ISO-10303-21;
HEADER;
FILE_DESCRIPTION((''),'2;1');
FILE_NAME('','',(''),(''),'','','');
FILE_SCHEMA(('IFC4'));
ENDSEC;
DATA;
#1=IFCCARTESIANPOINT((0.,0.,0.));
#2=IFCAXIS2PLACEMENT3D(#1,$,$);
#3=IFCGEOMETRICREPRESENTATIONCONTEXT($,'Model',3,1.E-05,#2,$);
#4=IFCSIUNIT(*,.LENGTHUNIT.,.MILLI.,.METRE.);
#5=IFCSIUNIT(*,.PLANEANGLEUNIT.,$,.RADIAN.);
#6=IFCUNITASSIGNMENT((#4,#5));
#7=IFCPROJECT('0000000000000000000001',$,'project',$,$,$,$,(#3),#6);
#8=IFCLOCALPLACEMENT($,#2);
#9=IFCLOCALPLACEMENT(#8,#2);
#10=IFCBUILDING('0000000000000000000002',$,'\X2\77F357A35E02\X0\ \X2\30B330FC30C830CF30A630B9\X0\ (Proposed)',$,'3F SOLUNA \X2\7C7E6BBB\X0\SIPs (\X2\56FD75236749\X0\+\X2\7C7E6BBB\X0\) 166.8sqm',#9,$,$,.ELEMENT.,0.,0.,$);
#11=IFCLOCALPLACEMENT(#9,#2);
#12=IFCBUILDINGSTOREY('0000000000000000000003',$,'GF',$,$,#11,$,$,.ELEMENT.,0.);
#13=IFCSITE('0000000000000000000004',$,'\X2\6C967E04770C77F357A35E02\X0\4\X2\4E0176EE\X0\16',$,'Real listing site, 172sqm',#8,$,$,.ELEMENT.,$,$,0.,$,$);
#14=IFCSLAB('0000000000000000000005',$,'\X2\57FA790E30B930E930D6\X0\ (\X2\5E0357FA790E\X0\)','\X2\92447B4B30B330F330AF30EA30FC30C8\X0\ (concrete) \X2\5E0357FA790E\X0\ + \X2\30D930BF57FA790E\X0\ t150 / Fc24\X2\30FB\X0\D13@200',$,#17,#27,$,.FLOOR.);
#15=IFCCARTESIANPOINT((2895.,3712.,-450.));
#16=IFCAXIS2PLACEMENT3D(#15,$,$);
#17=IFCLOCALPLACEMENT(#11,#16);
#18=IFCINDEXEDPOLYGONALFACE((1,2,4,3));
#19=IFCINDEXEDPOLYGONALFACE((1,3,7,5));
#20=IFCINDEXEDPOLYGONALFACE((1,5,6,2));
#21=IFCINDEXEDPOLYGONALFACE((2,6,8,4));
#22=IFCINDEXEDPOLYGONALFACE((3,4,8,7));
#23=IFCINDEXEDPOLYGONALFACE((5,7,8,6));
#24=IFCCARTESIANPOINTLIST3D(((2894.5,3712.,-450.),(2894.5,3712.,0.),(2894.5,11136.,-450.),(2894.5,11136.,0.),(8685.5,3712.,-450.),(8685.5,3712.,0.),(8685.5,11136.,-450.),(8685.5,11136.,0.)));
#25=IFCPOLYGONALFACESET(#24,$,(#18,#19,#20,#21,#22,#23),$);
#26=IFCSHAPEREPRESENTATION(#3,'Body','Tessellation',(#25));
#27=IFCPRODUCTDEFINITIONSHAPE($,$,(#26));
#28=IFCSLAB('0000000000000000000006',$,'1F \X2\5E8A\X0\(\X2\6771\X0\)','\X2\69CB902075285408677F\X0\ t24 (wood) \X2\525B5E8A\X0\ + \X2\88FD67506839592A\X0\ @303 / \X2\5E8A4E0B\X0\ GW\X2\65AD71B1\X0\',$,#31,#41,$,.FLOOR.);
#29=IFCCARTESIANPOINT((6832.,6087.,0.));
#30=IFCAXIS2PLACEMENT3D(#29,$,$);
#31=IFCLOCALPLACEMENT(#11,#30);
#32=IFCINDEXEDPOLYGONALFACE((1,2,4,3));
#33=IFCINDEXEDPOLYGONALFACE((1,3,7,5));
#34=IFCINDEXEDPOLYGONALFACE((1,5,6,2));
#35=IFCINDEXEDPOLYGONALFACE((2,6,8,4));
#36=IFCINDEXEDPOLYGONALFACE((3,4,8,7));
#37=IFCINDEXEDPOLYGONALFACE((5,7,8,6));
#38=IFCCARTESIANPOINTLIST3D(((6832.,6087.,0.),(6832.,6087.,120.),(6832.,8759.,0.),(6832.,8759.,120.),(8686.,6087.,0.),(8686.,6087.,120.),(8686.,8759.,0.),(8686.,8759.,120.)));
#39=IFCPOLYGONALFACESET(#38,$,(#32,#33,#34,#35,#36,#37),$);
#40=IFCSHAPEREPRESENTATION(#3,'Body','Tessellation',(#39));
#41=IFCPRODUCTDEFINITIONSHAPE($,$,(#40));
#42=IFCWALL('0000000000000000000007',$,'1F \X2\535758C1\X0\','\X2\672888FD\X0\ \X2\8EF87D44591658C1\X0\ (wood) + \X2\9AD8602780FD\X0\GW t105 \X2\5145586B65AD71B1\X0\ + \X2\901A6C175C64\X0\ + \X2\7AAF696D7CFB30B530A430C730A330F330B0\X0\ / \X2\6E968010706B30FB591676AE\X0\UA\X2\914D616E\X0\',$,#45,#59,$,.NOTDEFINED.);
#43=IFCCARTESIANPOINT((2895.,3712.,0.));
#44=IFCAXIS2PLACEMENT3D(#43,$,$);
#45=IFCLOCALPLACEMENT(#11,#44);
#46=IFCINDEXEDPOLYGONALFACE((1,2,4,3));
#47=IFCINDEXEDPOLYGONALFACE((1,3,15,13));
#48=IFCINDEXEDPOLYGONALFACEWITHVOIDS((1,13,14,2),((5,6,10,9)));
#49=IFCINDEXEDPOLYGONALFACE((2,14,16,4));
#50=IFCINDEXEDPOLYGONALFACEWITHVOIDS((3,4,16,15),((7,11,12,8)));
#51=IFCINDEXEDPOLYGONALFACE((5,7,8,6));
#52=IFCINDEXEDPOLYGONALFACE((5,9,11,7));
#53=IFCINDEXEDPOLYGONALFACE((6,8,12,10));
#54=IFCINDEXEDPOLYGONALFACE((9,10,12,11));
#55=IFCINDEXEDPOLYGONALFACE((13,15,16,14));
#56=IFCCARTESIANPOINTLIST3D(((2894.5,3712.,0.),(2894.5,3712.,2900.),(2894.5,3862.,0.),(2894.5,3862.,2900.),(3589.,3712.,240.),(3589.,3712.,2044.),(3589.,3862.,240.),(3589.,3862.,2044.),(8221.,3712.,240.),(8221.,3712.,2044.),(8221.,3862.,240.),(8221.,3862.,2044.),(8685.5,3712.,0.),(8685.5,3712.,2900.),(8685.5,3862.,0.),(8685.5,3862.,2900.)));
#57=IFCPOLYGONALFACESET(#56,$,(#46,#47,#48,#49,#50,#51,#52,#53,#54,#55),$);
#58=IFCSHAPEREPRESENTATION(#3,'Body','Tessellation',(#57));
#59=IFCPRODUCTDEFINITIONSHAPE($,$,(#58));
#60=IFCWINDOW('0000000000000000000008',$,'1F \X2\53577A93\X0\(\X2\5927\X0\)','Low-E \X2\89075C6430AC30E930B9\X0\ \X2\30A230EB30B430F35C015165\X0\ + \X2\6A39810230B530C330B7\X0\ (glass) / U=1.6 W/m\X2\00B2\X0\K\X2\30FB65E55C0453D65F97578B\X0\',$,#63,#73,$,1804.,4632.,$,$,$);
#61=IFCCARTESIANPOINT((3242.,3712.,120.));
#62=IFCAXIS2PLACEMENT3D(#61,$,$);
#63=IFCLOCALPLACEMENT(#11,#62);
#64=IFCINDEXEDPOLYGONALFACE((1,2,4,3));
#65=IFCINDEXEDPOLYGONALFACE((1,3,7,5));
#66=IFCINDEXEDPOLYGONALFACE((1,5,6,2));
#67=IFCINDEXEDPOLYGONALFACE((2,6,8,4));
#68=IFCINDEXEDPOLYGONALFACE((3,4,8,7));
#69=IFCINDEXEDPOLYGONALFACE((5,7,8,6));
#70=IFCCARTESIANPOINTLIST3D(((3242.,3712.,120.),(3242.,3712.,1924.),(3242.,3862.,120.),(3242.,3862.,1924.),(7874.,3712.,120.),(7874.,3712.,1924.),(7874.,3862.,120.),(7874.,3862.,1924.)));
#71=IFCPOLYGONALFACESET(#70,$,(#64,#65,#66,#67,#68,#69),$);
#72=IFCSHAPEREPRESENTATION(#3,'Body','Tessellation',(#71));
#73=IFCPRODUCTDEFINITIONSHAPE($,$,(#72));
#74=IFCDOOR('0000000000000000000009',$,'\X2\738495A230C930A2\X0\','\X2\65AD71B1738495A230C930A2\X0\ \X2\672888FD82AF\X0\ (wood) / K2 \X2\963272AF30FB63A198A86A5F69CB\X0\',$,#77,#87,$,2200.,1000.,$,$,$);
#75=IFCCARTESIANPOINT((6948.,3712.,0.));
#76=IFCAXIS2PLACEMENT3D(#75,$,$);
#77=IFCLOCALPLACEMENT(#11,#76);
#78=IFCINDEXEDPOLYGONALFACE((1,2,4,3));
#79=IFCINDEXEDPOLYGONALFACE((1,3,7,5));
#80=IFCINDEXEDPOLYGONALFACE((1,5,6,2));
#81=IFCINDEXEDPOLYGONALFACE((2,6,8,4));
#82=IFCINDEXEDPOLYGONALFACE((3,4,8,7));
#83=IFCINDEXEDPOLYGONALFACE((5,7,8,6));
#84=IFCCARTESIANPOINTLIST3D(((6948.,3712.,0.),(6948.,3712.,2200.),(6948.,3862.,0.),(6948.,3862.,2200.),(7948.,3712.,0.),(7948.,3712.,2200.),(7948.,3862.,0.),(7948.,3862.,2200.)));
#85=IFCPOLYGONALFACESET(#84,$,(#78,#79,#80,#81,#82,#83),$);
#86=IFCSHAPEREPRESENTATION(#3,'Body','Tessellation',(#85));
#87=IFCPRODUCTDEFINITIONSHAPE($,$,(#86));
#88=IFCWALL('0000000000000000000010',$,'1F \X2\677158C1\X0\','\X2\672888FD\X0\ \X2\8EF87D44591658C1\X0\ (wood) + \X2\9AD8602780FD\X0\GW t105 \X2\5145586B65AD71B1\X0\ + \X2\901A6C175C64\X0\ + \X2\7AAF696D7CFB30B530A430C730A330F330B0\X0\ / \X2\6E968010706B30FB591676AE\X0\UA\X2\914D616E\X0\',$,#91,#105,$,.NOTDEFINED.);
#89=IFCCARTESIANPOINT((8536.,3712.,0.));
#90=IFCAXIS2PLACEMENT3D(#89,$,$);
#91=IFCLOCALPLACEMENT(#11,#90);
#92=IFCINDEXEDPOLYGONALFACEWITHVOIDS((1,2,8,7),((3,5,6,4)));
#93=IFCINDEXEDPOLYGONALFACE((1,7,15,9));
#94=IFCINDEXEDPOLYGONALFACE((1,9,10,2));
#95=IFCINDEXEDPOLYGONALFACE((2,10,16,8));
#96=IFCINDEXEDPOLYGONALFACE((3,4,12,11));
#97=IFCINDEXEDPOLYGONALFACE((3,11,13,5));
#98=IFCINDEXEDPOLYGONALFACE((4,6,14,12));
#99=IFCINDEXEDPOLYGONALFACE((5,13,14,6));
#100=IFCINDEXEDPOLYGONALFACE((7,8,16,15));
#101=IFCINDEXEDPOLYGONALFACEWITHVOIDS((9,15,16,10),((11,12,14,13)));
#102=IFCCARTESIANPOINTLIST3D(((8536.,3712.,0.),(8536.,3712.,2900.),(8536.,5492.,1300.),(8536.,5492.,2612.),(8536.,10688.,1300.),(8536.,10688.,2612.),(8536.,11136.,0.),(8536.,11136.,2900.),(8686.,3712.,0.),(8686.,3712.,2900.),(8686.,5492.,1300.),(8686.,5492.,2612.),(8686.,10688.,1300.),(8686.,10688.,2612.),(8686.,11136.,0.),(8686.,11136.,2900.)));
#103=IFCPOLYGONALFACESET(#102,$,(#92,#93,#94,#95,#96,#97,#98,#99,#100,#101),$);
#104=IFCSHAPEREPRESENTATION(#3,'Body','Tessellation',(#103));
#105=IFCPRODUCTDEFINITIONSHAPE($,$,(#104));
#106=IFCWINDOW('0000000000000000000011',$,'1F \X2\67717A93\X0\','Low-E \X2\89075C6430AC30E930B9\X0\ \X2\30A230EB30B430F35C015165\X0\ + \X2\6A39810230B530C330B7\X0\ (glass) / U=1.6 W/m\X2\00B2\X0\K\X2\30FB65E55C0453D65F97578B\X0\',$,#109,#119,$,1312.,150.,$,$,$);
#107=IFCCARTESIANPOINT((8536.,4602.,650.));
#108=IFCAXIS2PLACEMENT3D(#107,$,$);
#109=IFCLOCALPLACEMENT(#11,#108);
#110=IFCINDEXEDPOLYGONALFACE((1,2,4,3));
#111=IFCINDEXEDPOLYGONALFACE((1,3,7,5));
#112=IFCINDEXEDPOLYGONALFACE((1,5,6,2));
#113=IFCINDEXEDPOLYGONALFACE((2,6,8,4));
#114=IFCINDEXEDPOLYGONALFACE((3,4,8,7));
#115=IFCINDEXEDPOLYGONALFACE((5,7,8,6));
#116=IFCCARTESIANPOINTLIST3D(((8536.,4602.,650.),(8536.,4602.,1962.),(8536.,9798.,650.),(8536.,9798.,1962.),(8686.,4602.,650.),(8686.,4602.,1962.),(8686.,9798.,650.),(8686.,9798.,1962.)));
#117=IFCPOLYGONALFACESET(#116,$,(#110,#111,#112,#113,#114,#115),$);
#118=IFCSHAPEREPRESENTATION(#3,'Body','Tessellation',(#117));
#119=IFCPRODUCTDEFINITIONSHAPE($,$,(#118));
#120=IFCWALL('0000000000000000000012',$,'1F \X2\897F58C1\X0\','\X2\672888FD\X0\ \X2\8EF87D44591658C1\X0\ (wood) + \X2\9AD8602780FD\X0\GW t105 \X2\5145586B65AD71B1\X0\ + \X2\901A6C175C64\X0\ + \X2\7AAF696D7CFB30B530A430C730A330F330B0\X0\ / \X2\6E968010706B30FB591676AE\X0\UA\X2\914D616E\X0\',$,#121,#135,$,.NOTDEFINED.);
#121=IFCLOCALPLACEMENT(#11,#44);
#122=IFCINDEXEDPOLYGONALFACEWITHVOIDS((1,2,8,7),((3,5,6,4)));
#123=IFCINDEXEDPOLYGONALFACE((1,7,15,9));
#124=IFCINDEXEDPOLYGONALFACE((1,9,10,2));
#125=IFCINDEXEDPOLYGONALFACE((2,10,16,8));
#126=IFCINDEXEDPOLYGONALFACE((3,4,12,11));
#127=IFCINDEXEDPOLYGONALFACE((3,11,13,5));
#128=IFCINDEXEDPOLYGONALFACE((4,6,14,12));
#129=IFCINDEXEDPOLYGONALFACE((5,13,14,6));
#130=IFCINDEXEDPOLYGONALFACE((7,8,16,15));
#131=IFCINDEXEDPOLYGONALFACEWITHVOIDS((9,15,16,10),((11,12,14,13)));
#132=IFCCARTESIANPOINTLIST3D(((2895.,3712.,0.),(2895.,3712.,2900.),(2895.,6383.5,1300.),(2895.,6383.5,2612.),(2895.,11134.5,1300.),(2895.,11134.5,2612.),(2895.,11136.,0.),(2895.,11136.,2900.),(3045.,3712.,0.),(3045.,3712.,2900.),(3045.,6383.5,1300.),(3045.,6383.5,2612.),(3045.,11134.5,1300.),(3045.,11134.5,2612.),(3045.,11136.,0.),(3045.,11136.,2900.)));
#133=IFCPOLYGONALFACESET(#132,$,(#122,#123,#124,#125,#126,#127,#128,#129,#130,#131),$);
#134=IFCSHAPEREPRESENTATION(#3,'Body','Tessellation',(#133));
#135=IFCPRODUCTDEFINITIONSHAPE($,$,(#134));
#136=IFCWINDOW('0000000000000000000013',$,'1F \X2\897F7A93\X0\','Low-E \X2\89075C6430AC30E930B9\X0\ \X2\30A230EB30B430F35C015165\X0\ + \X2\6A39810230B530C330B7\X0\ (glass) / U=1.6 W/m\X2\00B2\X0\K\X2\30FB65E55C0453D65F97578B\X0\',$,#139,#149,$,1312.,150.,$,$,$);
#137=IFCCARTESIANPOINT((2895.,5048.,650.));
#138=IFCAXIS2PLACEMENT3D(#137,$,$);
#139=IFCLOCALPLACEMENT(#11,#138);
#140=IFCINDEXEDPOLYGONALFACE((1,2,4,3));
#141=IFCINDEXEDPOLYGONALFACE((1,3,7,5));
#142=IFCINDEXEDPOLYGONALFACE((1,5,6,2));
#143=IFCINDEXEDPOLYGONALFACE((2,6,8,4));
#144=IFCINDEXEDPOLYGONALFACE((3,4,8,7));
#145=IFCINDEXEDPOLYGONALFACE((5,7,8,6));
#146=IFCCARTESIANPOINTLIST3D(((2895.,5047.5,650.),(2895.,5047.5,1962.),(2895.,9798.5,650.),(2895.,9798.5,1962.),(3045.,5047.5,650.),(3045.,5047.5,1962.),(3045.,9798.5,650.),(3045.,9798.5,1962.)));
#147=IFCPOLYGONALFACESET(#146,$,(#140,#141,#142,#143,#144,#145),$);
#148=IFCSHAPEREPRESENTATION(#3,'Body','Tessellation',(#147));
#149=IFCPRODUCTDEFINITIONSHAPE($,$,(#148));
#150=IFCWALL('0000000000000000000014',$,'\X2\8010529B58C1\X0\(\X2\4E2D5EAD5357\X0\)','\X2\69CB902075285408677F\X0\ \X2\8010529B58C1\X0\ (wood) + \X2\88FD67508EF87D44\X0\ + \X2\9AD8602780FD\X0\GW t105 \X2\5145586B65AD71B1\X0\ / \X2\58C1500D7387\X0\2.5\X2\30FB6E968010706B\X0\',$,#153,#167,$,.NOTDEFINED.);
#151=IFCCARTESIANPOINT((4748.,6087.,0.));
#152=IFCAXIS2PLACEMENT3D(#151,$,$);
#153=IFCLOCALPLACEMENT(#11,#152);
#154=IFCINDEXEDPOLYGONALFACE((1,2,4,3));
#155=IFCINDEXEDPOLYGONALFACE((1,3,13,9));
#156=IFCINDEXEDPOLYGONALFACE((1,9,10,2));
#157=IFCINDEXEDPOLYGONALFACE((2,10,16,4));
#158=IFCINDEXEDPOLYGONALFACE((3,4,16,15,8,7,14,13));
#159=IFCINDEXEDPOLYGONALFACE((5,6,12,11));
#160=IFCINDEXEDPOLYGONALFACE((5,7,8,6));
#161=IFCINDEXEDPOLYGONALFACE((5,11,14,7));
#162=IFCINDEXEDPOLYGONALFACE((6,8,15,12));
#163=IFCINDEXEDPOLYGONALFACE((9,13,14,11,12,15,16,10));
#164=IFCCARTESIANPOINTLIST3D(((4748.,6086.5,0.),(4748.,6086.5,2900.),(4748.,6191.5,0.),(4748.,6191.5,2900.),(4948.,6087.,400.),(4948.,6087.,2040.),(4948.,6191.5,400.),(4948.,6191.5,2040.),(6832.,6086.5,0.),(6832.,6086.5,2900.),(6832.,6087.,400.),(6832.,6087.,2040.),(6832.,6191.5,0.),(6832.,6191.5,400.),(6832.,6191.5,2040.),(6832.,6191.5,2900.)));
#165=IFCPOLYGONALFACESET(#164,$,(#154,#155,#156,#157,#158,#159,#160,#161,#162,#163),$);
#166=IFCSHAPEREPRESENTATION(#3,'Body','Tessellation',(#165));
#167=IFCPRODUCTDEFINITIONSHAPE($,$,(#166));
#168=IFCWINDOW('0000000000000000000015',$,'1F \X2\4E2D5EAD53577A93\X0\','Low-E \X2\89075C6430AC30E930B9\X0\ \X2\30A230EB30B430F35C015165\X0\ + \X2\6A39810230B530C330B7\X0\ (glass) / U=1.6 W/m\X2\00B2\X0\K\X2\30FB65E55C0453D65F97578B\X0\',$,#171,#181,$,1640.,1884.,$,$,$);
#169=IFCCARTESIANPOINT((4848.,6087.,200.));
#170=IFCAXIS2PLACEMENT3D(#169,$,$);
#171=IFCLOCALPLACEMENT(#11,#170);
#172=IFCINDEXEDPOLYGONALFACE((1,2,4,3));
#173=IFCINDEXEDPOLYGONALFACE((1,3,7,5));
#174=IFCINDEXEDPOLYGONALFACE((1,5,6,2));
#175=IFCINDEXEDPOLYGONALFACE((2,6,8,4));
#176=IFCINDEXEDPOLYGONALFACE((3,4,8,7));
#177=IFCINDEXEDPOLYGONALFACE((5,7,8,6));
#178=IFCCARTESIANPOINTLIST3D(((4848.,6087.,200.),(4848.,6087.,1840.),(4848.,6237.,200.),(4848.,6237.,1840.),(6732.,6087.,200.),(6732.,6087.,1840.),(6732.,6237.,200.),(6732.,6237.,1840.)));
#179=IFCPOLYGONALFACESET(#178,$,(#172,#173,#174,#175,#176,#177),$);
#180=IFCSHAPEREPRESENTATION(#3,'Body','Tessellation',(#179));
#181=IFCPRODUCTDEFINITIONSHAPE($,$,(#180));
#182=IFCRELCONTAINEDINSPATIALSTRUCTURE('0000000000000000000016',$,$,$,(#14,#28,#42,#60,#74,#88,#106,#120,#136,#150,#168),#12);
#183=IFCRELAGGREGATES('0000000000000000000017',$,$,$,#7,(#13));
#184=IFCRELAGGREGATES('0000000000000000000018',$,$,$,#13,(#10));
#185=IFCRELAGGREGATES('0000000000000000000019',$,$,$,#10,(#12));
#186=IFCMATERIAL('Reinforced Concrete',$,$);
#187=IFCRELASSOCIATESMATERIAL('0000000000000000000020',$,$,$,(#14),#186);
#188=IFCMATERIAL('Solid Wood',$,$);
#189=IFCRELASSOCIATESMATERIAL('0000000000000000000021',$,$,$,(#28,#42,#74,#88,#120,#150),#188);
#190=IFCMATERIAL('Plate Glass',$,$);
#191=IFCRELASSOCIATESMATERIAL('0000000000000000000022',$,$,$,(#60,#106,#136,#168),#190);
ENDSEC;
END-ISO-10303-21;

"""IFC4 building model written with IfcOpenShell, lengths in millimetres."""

from ifc_helpers import new_model, si_unit, frame, frame_2d, origin, place, context, project, spatial, rectangle, extrude, material, element, fill, save


model = new_model("IFC4")

# Units and contexts
model_context = context("Model", 3, precision=1e-05, world=origin())
ifc_project = project(units=[si_unit("LENGTHUNIT", "METRE", prefix="MILLI"), si_unit("PLANEANGLEUNIT", "RADIAN")], contexts=[model_context])

# Site, building, storey
site_placement = place(None, origin())
site = spatial("IfcSite", under=ifc_project, at=site_placement, Name="沖縄県石垣市4丁目16", ObjectType="Real listing site, 172sqm", CompositionType="ELEMENT", RefElevation=0.0)
building_placement = place(site_placement, origin())
building = spatial("IfcBuilding", under=site, at=building_placement, Name="石垣市 コートハウス (Proposed)", ObjectType="3F SOLUNA 籾殻SIPs (国産杉+籾殻) 166.8sqm", CompositionType="ELEMENT", ElevationOfRefHeight=0.0, ElevationOfTerrain=0.0)
storey_placement = place(building_placement, origin())
storey = spatial("IfcBuildingStorey", under=building, at=storey_placement, Name="GF", CompositionType="ELEMENT", Elevation=0.0)

# Slabs
ifc_material_1 = material(Name="Reinforced Concrete")
slab_1_placement = place(storey_placement, frame((2895.0, 3712.0, -450.0)))
element("IfcSlab", 1, at=slab_1_placement, inside=storey, material=ifc_material_1, Name="基礎スラブ (布基礎)", Description="鉄筋コンクリート (concrete) 布基礎 + ベタ基礎 t150 / Fc24・D13@200", PredefinedType="FLOOR", context=model_context, shape_type="SweptSolid", body=[
    extrude(rectangle(XDim=5791.0, YDim=7424.0, at=frame_2d((2895.0, 3712.0))), frame((2895.0, 3712.0, -450.0)), (0.0, 0.0, 1.0), 450.0),
])
ifc_material_2 = material(Name="Solid Wood")
slab_2_placement = place(storey_placement, frame((6832.0, 6087.0, 0.0)))
element("IfcSlab", 2, at=slab_2_placement, inside=storey, material=ifc_material_2, Name="1F 床(東)", Description="構造用合板 t24 (wood) 剛床 + 製材根太 @303 / 床下 GW断熱", PredefinedType="FLOOR", context=model_context, shape_type="SweptSolid", body=[
    extrude(rectangle(XDim=1854.0, YDim=2672.0, at=frame_2d((927.0, 1336.0))), frame((6832.0, 6087.0, 0.0)), (0.0, 0.0, 1.0), 120.0),
])

# Wall, openings, window, door
wall_1_placement = place(storey_placement, frame((2895.0, 3712.0, 0.0)))
wall_1 = element("IfcWall", 3, at=wall_1_placement, inside=storey, material=ifc_material_2, Name="1F 南壁", Description="木製 軸組外壁 (wood) + 高性能GW t105 充填断熱 + 通気層 + 窯業系サイディング / 準耐火・外皮UA配慮", PredefinedType="NOTDEFINED", context=model_context, shape_type="SweptSolid", body=[
    extrude(rectangle(XDim=5791.0, YDim=150.0, at=frame_2d((2895.0, 75.0))), frame((2895.0, 3712.0, 0.0)), (0.0, 0.0, 1.0), 2900.0),
])
opening_1_placement = place(storey_placement, frame((3242.0, 3712.0, 120.0)))
opening_1 = element("IfcOpeningElement", 4, at=opening_1_placement, cuts=wall_1, PredefinedType="NOTDEFINED", context=model_context, shape_type="SweptSolid", body=[
    extrude(rectangle(XDim=4632.0, YDim=150.0, at=frame_2d((2316.0, 75.0))), frame((3242.0, 3712.0, 120.0)), (0.0, 0.0, 1.0), 1804.0),
])
opening_2_placement = place(storey_placement, frame((6948.0, 3712.0, 0.0)))
opening_2 = element("IfcOpeningElement", 5, at=opening_2_placement, cuts=wall_1, PredefinedType="NOTDEFINED", context=model_context, shape_type="SweptSolid", body=[
    extrude(rectangle(XDim=1000.0, YDim=150.0, at=frame_2d((500.0, 75.0))), frame((6948.0, 3712.0, 0.0)), (0.0, 0.0, 1.0), 2200.0),
])
ifc_material_3 = material(Name="Plate Glass")
window_1_placement = place(storey_placement, frame((3242.0, 3712.0, 120.0)))
window_1 = element("IfcWindow", 6, at=window_1_placement, inside=storey, material=ifc_material_3, Name="1F 南窓(大)", Description="Low-E 複層ガラス アルゴン封入 + 樹脂サッシ (glass) / U=1.6 W/m²K・日射取得型", OverallHeight=1804.0, OverallWidth=4632.0, context=model_context, shape_type="SweptSolid", body=[
    extrude(rectangle(XDim=4632.0, YDim=150.0, at=frame_2d((2316.0, 75.0))), frame((3242.0, 3712.0, 120.0)), (0.0, 0.0, 1.0), 1804.0),
])
fill(opening_1, window_1)
door_placement = place(storey_placement, frame((6948.0, 3712.0, 0.0)))
door = element("IfcDoor", 7, at=door_placement, inside=storey, material=ifc_material_2, Name="玄関ドア", Description="断熱玄関ドア 木製芯 (wood) / K2 防犯・採風機構", OverallHeight=2200.0, OverallWidth=1000.0, context=model_context, shape_type="SweptSolid", body=[
    extrude(rectangle(XDim=1000.0, YDim=150.0, at=frame_2d((500.0, 75.0))), frame((6948.0, 3712.0, 0.0)), (0.0, 0.0, 1.0), 2200.0),
])
fill(opening_2, door)

# Walls, openings, windows
wall_2_placement = place(storey_placement, frame((8536.0, 3712.0, 0.0)))
wall_2 = element("IfcWall", 8, at=wall_2_placement, inside=storey, material=ifc_material_2, Name="1F 東壁", Description="木製 軸組外壁 (wood) + 高性能GW t105 充填断熱 + 通気層 + 窯業系サイディング / 準耐火・外皮UA配慮", PredefinedType="NOTDEFINED", context=model_context, shape_type="SweptSolid", body=[
    extrude(rectangle(XDim=150.0, YDim=7424.0, at=frame_2d((75.0, 3712.0))), frame((8536.0, 3712.0, 0.0)), (0.0, 0.0, 1.0), 2900.0),
])
opening_3_placement = place(storey_placement, frame((8536.0, 4602.0, 650.0)))
opening_3 = element("IfcOpeningElement", 9, at=opening_3_placement, cuts=wall_2, PredefinedType="NOTDEFINED", context=model_context, shape_type="SweptSolid", body=[
    extrude(rectangle(XDim=150.0, YDim=5196.0, at=frame_2d((75.0, 2598.0))), frame((8536.0, 4602.0, 650.0)), (0.0, 0.0, 1.0), 1312.0),
])
window_2_placement = place(storey_placement, frame((8536.0, 4602.0, 650.0)))
window_2 = element("IfcWindow", 10, at=window_2_placement, inside=storey, material=ifc_material_3, Name="1F 東窓", Description="Low-E 複層ガラス アルゴン封入 + 樹脂サッシ (glass) / U=1.6 W/m²K・日射取得型", OverallHeight=1312.0, OverallWidth=150.0, context=model_context, shape_type="SweptSolid", body=[
    extrude(rectangle(XDim=150.0, YDim=5196.0, at=frame_2d((75.0, 2598.0))), frame((8536.0, 4602.0, 650.0)), (0.0, 0.0, 1.0), 1312.0),
])
fill(opening_3, window_2)
wall_3_placement = place(storey_placement, frame((2895.0, 3712.0, 0.0)))
wall_3 = element("IfcWall", 11, at=wall_3_placement, inside=storey, material=ifc_material_2, Name="1F 西壁", Description="木製 軸組外壁 (wood) + 高性能GW t105 充填断熱 + 通気層 + 窯業系サイディング / 準耐火・外皮UA配慮", PredefinedType="NOTDEFINED", context=model_context, shape_type="SweptSolid", body=[
    extrude(rectangle(XDim=150.0, YDim=7424.0, at=frame_2d((75.0, 3712.0))), frame((2895.0, 3712.0, 0.0)), (0.0, 0.0, 1.0), 2900.0),
])
opening_4_placement = place(storey_placement, frame((2895.0, 5048.0, 650.0)))
opening_4 = element("IfcOpeningElement", 12, at=opening_4_placement, cuts=wall_3, PredefinedType="NOTDEFINED", context=model_context, shape_type="SweptSolid", body=[
    extrude(rectangle(XDim=150.0, YDim=4751.0, at=frame_2d((75.0, 2375.0))), frame((2895.0, 5048.0, 650.0)), (0.0, 0.0, 1.0), 1312.0),
])
window_3_placement = place(storey_placement, frame((2895.0, 5048.0, 650.0)))
window_3 = element("IfcWindow", 13, at=window_3_placement, inside=storey, material=ifc_material_3, Name="1F 西窓", Description="Low-E 複層ガラス アルゴン封入 + 樹脂サッシ (glass) / U=1.6 W/m²K・日射取得型", OverallHeight=1312.0, OverallWidth=150.0, context=model_context, shape_type="SweptSolid", body=[
    extrude(rectangle(XDim=150.0, YDim=4751.0, at=frame_2d((75.0, 2375.0))), frame((2895.0, 5048.0, 650.0)), (0.0, 0.0, 1.0), 1312.0),
])
fill(opening_4, window_3)
wall_4_placement = place(storey_placement, frame((4748.0, 6087.0, 0.0)))
wall_4 = element("IfcWall", 14, at=wall_4_placement, inside=storey, material=ifc_material_2, Name="耐力壁(中庭南)", Description="構造用合板 耐力壁 (wood) + 製材軸組 + 高性能GW t105 充填断熱 / 壁倍率2.5・準耐火", PredefinedType="NOTDEFINED", context=model_context, shape_type="SweptSolid", body=[
    extrude(rectangle(XDim=2084.0, YDim=105.0, at=frame_2d((1042.0, 52.0))), frame((4748.0, 6087.0, 0.0)), (0.0, 0.0, 1.0), 2900.0),
])
opening_5_placement = place(storey_placement, frame((4848.0, 6087.0, 200.0)))
opening_5 = element("IfcOpeningElement", 15, at=opening_5_placement, cuts=wall_4, PredefinedType="NOTDEFINED", context=model_context, shape_type="SweptSolid", body=[
    extrude(rectangle(XDim=1884.0, YDim=150.0, at=frame_2d((942.0, 75.0))), frame((4848.0, 6087.0, 200.0)), (0.0, 0.0, 1.0), 1640.0),
])
window_4_placement = place(storey_placement, frame((4848.0, 6087.0, 200.0)))
window_4 = element("IfcWindow", 16, at=window_4_placement, inside=storey, material=ifc_material_3, Name="1F 中庭南窓", Description="Low-E 複層ガラス アルゴン封入 + 樹脂サッシ (glass) / U=1.6 W/m²K・日射取得型", OverallHeight=1640.0, OverallWidth=1884.0, context=model_context, shape_type="SweptSolid", body=[
    extrude(rectangle(XDim=1884.0, YDim=150.0, at=frame_2d((942.0, 75.0))), frame((4848.0, 6087.0, 200.0)), (0.0, 0.0, 1.0), 1640.0),
])
fill(opening_5, window_4)

save(model, "model.ifc")
